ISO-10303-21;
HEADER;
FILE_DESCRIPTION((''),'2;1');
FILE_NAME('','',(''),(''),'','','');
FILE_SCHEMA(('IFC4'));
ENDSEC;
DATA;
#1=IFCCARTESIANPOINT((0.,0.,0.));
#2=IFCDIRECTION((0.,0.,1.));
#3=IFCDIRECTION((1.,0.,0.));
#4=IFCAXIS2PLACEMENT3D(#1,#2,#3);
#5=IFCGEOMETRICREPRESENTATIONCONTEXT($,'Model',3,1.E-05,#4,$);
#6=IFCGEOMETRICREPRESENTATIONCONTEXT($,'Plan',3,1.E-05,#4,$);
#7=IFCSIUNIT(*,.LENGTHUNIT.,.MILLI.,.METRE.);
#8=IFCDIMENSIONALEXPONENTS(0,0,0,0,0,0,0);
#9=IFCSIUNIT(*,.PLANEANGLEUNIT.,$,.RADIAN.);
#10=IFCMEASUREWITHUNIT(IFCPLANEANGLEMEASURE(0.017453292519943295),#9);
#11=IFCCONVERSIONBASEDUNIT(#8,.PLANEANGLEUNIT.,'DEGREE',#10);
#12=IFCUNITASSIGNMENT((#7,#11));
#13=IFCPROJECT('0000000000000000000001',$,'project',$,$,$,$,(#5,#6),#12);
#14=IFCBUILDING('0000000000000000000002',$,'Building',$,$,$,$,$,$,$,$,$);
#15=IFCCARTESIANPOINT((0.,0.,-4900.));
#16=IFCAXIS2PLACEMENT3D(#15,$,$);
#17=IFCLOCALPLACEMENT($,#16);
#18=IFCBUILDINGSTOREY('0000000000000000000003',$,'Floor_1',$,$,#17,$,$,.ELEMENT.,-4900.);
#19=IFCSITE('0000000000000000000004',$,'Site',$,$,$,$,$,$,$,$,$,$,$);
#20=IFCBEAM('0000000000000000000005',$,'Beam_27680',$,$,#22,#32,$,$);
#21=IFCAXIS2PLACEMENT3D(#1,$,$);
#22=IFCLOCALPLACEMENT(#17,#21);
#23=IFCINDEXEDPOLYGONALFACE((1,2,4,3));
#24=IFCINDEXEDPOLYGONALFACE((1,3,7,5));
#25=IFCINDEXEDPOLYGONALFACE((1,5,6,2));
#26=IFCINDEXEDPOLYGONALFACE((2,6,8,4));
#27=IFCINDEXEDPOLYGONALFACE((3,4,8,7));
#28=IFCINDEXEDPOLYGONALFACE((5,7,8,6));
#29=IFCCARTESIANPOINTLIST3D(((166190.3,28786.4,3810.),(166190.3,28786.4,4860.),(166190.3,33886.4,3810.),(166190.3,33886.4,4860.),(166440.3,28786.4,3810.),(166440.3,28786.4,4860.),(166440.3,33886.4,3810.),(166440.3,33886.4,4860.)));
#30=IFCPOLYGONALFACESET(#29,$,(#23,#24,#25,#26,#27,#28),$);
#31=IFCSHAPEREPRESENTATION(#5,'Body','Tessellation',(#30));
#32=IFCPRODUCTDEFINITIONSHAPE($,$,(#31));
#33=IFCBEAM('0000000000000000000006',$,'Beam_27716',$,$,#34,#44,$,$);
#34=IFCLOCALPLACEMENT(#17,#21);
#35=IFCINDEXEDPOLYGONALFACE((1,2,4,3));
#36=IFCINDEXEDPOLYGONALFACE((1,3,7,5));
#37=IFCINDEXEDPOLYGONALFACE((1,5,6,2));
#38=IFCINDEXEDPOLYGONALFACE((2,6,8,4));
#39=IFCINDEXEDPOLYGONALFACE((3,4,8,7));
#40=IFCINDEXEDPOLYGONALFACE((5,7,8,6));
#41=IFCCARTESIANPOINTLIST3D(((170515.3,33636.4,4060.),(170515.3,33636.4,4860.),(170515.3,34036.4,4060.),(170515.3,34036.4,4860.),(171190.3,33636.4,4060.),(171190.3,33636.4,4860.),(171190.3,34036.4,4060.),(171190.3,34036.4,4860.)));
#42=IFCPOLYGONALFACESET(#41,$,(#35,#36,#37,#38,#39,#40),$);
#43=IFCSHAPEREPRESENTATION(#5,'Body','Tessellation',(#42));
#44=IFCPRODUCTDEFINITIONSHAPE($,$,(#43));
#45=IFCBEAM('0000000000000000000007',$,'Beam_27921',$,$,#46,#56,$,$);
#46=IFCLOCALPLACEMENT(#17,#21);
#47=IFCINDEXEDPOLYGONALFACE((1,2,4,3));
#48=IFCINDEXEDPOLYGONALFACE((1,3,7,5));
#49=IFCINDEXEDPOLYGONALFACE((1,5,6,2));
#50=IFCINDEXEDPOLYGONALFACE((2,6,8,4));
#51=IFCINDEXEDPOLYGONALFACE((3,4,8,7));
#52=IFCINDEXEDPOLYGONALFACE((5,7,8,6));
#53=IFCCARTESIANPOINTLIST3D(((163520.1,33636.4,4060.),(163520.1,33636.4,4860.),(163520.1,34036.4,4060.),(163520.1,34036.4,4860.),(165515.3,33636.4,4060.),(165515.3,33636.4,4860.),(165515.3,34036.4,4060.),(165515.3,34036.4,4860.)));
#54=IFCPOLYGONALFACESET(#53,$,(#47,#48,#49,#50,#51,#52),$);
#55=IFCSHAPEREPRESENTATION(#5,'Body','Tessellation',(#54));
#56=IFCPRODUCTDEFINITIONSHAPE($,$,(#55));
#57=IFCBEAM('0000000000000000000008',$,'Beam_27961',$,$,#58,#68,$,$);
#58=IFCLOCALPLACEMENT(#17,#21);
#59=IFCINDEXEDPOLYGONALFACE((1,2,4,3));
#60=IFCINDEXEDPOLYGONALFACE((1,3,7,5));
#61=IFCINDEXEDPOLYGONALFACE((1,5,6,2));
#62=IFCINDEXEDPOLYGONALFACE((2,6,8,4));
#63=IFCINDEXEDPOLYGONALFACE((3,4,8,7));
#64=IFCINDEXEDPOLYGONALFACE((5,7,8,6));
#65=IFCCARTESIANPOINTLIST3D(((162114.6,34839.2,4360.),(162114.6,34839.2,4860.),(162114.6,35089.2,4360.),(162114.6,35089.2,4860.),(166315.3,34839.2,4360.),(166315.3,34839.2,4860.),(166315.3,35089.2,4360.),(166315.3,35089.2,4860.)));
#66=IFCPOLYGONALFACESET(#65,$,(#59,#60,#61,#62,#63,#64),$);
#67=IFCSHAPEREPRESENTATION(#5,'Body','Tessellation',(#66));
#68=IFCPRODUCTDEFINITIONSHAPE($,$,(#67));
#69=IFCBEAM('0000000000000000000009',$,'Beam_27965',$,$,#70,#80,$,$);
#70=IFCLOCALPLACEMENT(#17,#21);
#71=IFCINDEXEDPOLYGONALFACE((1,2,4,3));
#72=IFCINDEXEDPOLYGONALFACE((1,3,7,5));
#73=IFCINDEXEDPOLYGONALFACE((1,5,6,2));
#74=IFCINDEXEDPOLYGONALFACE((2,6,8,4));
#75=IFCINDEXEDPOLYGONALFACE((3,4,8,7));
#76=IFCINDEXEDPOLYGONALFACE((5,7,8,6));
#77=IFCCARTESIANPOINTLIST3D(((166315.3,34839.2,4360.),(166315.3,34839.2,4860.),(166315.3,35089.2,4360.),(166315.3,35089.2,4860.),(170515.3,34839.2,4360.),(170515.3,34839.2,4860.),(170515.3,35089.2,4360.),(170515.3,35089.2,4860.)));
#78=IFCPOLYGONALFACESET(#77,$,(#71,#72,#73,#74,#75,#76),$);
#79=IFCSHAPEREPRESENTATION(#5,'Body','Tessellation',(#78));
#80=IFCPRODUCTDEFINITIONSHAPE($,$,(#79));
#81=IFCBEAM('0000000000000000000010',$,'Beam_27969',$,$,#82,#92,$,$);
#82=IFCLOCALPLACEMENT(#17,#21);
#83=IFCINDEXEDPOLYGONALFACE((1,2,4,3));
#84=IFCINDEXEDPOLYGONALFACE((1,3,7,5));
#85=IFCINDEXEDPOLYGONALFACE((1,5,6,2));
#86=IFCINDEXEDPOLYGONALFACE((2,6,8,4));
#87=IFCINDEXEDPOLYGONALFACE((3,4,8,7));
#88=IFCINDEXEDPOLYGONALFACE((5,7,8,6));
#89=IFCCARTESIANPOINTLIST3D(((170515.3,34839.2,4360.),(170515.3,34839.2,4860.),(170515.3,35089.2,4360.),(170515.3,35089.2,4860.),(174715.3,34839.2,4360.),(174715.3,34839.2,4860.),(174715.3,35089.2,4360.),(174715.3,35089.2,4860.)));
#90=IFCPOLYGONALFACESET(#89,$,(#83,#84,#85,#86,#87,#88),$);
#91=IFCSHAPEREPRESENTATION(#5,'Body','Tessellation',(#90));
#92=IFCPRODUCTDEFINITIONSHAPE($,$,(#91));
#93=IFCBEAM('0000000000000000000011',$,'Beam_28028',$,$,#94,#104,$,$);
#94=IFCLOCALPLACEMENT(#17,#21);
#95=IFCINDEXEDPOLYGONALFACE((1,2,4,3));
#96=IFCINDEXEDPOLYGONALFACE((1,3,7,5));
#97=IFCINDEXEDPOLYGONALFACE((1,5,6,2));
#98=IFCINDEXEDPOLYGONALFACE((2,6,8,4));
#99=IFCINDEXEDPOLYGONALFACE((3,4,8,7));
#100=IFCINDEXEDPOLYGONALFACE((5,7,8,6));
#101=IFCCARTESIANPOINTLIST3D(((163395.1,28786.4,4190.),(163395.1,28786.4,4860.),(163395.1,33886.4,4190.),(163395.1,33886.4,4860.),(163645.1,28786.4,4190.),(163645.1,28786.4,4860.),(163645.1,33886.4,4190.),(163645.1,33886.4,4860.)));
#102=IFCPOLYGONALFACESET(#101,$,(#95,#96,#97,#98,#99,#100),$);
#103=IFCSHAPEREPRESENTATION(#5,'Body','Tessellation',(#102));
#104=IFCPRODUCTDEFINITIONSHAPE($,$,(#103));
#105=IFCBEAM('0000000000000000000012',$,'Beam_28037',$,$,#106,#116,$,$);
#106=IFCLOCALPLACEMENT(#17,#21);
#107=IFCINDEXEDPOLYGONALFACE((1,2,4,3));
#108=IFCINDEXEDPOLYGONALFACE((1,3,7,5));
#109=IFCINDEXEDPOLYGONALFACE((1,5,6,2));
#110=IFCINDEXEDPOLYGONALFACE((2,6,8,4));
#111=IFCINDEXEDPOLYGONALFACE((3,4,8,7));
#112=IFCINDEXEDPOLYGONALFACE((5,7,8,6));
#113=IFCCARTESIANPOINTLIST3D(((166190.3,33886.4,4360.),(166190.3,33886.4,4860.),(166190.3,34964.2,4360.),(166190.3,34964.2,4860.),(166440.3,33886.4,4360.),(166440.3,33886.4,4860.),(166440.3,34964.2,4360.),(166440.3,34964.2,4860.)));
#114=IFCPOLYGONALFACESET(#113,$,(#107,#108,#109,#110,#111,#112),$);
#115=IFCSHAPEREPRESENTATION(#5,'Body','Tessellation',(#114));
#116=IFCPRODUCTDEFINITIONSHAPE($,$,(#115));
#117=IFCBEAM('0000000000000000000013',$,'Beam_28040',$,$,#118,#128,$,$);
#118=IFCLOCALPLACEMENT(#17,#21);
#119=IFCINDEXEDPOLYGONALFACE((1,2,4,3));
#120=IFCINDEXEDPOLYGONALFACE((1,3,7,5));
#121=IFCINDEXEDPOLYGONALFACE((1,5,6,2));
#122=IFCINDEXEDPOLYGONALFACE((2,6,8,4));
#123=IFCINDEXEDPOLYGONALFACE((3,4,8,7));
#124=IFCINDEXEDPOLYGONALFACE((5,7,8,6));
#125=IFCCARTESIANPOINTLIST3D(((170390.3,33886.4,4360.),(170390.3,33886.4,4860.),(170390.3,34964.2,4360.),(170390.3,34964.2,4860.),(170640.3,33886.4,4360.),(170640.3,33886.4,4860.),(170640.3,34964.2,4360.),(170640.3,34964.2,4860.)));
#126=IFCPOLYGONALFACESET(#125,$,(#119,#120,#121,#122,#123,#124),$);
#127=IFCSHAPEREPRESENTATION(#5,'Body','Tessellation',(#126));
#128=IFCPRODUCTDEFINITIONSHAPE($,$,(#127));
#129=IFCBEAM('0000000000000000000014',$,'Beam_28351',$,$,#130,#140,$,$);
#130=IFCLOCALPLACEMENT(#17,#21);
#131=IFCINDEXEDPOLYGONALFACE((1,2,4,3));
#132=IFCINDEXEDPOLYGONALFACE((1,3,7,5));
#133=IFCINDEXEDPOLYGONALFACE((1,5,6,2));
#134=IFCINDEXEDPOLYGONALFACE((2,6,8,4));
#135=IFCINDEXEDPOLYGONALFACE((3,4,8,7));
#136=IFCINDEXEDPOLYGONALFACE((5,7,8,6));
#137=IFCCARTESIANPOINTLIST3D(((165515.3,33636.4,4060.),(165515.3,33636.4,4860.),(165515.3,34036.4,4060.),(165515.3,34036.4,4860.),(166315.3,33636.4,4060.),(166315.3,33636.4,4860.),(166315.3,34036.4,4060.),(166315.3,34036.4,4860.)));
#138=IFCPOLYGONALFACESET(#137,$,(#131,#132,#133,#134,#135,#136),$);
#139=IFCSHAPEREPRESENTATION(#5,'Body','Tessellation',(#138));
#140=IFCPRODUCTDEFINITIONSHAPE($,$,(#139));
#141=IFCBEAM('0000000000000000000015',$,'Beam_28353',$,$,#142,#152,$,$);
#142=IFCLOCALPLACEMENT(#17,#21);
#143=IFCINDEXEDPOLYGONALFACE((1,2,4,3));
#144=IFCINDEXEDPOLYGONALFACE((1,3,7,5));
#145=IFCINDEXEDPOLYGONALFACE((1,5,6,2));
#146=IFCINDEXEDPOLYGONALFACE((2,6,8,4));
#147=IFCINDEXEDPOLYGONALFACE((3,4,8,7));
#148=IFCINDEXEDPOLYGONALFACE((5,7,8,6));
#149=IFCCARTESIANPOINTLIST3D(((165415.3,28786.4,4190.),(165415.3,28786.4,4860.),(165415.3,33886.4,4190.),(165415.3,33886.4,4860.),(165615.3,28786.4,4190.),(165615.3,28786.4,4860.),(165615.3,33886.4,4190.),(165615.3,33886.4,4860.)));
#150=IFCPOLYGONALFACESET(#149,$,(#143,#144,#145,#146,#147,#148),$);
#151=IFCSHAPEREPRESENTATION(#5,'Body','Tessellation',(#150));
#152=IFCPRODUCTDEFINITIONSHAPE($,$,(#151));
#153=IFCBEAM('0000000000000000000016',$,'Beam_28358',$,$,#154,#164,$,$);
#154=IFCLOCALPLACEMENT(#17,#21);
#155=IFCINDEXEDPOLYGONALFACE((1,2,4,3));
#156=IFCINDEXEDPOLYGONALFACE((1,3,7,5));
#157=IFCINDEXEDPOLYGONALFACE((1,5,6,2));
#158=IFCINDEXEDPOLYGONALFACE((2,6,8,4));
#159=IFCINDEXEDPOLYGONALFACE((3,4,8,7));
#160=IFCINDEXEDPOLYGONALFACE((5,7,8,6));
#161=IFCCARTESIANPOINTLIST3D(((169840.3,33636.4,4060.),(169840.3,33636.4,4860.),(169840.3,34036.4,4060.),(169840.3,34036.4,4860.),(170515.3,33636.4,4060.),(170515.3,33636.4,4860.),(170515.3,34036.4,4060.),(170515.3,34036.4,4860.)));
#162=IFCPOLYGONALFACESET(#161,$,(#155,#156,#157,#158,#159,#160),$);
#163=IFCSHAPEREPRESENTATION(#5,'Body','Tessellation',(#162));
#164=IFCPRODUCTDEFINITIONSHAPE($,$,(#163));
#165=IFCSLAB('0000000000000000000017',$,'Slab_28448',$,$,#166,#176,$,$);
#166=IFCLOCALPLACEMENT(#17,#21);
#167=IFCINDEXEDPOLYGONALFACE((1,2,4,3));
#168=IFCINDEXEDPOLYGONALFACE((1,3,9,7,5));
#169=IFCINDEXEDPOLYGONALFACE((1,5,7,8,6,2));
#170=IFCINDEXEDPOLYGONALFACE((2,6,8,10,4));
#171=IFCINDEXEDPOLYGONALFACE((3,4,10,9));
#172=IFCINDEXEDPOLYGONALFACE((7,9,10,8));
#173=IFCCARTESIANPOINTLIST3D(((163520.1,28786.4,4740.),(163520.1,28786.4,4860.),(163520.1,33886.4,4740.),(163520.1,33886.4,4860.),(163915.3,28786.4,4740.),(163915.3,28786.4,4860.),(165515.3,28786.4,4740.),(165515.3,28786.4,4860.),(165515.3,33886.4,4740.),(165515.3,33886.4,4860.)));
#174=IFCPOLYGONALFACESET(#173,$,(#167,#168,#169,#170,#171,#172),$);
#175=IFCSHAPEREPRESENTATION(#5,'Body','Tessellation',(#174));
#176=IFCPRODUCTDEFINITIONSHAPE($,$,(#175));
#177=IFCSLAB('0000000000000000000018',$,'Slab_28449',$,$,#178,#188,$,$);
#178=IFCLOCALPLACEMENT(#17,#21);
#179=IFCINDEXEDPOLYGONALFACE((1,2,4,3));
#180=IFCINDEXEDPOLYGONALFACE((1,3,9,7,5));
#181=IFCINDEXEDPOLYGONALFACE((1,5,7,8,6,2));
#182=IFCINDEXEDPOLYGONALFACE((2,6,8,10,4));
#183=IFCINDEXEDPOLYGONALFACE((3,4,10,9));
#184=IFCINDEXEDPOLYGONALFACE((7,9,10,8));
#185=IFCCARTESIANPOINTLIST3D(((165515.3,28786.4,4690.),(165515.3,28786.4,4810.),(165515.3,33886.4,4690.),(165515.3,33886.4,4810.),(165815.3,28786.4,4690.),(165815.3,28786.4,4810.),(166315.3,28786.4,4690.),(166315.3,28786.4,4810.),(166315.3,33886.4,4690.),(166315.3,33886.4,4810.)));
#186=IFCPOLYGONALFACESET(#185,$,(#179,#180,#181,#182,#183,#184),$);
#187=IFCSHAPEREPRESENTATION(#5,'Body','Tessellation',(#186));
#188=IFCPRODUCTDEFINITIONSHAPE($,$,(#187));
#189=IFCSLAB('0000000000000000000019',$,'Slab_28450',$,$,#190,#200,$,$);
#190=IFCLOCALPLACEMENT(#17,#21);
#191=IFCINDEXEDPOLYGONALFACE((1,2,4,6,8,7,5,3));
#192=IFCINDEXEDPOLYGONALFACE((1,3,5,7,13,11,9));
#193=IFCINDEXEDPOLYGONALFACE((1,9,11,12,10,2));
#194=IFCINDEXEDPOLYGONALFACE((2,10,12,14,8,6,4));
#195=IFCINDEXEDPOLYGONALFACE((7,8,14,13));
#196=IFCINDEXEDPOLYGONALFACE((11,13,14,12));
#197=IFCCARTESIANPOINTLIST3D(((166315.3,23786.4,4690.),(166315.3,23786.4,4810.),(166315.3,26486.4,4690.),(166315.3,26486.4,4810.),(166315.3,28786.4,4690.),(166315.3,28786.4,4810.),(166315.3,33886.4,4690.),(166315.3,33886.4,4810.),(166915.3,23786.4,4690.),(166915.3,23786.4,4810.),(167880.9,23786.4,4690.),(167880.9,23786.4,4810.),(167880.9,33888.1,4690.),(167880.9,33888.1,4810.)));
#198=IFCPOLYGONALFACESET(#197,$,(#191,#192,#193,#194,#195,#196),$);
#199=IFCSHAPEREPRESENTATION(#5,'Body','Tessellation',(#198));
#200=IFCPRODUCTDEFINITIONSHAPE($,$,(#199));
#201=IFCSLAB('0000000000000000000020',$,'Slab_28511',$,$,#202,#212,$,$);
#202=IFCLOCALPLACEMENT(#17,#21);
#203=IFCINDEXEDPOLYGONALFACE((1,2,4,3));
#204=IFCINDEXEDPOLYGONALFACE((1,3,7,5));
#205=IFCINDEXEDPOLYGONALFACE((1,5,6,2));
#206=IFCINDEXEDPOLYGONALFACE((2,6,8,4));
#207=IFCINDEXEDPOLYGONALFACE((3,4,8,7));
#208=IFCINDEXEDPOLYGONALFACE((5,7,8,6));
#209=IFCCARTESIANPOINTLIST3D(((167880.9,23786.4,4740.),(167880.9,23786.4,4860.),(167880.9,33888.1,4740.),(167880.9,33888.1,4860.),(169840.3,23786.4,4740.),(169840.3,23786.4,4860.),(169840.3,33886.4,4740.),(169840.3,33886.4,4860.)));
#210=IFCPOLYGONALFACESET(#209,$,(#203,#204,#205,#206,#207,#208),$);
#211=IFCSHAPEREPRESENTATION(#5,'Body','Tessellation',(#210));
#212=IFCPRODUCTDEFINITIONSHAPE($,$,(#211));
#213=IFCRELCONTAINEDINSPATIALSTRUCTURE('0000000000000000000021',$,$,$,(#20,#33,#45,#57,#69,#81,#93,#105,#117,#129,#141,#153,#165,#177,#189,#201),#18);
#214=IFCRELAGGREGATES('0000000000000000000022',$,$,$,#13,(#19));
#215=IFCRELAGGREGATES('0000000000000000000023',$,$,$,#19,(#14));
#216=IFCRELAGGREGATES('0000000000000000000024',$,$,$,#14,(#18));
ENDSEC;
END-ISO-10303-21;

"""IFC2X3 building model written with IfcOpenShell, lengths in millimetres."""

from ifc_helpers import new_model, entity, si_unit, converted_unit, frame, origin_with_axes, origin_2d, place, context, project, spatial, polyline, rectangle, outline, extrude, element, save


model = new_model("IFC2X3")

# Units and contexts
model_context = context("Model", 3, precision=1e-05, world=origin_with_axes())
plan_context = context("Plan", 3, precision=1e-05, world=origin_with_axes())
ifc_project = project(units=[si_unit("LENGTHUNIT", "METRE", prefix="MILLI"), converted_unit("PLANEANGLEUNIT", "DEGREE", entity("IfcPlaneAngleMeasure", 0.017453292519943295), si_unit("PLANEANGLEUNIT", "RADIAN"), dimensions=[0, 0, 0, 0, 0, 0, 0])], contexts=[model_context, plan_context])

# Site, building, storey
site = spatial("IfcSite", under=ifc_project, Name="Site")
building = spatial("IfcBuilding", under=site, Name="Building")
storey_placement = place(None, frame((0.0, 0.0, -4900.0)))
storey = spatial("IfcBuildingStorey", under=building, at=storey_placement, Name="Floor_1", CompositionType="ELEMENT", Elevation=-4900.0)

# Beams
beam_1_placement = place(storey_placement, frame((166315.3, 28786.4, 4335.0), z_axis=(0.000484, 5099.99974, 0.0), x_axis=(5099.99974, -0.000484, 0.0)))
element("IfcBeam", 1, at=beam_1_placement, inside=storey, Name="Beam_27680", context=model_context, shape_type="SweptSolid", body=[
    extrude(rectangle(XDim=250.0, YDim=1050.0, at=origin_2d()), origin_with_axes(), (0.0, 0.0, 1.0), 5100.0),
])
beam_2_placement = place(storey_placement, frame((170515.3, 33836.4, 4460.0), z_axis=(675.0, 0.0, 0.0), x_axis=(0.0, -675.0, 0.0)))
element("IfcBeam", 2, at=beam_2_placement, inside=storey, Name="Beam_27716", context=model_context, shape_type="SweptSolid", body=[
    extrude(rectangle(XDim=400.0, YDim=800.0, at=origin_2d()), origin_with_axes(), (0.0, 0.0, 1.0), 675.0),
])
beam_3_placement = place(storey_placement, frame((163520.1, 33836.4, 4460.0), z_axis=(1995.269571, 0.0, 0.0), x_axis=(0.0, -1995.269571, 0.0)))
element("IfcBeam", 3, at=beam_3_placement, inside=storey, Name="Beam_27921", context=model_context, shape_type="SweptSolid", body=[
    extrude(rectangle(XDim=400.0, YDim=800.0, at=origin_2d()), origin_with_axes(), (0.0, 0.0, 1.0), 1995.3),
])
beam_4_placement = place(storey_placement, frame((162114.6, 34964.2, 4610.0), z_axis=(4200.682337, 0.0, 0.0), x_axis=(0.0, -4200.682337, 0.0)))
element("IfcBeam", 4, at=beam_4_placement, inside=storey, Name="Beam_27961", context=model_context, shape_type="SweptSolid", body=[
    extrude(rectangle(XDim=250.0, YDim=500.0, at=origin_2d()), origin_with_axes(), (0.0, 0.0, 1.0), 4200.7),
])
for number, where, z_axis, x_axis, name in (
    (5, (166315.3, 34964.2, 4610.0), (4200.0, 0.0, 0.0), (0.0, -4200.0, 0.0), "Beam_27965"),
    (6, (170515.3, 34964.2, 4610.0), (4200.0, 0.0, 0.0), (0.0, -4200.0, 0.0), "Beam_27969"),
):
    element("IfcBeam", number, at=place(storey_placement, frame(where, z_axis=z_axis, x_axis=x_axis)), inside=storey, Name=name, context=model_context, shape_type="SweptSolid", body=[
        extrude(rectangle(XDim=250.0, YDim=500.0, at=origin_2d()), origin_with_axes(), (0.0, 0.0, 1.0), 4200.0),
    ])
beam_5_placement = place(storey_placement, frame((163520.1, 28786.4, 4525.0), z_axis=(0.0, 5099.99974, 0.0), x_axis=(5099.99974, 0.0, 0.0)))
element("IfcBeam", 7, at=beam_5_placement, inside=storey, Name="Beam_28028", context=model_context, shape_type="SweptSolid", body=[
    extrude(rectangle(XDim=250.0, YDim=670.0, at=origin_2d()), origin_with_axes(), (0.0, 0.0, 1.0), 5100.0),
])
for number, where, z_axis, x_axis, name in (
    (8, (166315.3, 33886.4, 4610.0), (0.0, 1077.803188, 0.0), (1077.803188, 0.0, 0.0), "Beam_28037"),
    (9, (170515.3, 33886.4, 4610.0), (0.0, 1077.803188, 0.0), (1077.803188, 0.0, 0.0), "Beam_28040"),
):
    element("IfcBeam", number, at=place(storey_placement, frame(where, z_axis=z_axis, x_axis=x_axis)), inside=storey, Name=name, context=model_context, shape_type="SweptSolid", body=[
        extrude(rectangle(XDim=250.0, YDim=500.0, at=origin_2d()), origin_with_axes(), (0.0, 0.0, 1.0), 1077.8),
    ])
beam_6_placement = place(storey_placement, frame((165515.3, 33836.4, 4460.0), z_axis=(800.0, 0.0, 0.0), x_axis=(0.0, -800.0, 0.0)))
element("IfcBeam", 10, at=beam_6_placement, inside=storey, Name="Beam_28351", context=model_context, shape_type="SweptSolid", body=[
    extrude(rectangle(XDim=400.0, YDim=800.0, at=origin_2d()), origin_with_axes(), (0.0, 0.0, 1.0), 800.0),
])
beam_7_placement = place(storey_placement, frame((165515.3, 28786.4, 4525.0), z_axis=(0.0, 5099.99974, 0.0), x_axis=(5099.99974, 0.0, 0.0)))
element("IfcBeam", 11, at=beam_7_placement, inside=storey, Name="Beam_28353", context=model_context, shape_type="SweptSolid", body=[
    extrude(rectangle(XDim=200.0, YDim=670.0, at=origin_2d()), origin_with_axes(), (0.0, 0.0, 1.0), 5100.0),
])
beam_8_placement = place(storey_placement, frame((169840.3, 33836.4, 4460.0), z_axis=(675.0, 0.0, 0.0), x_axis=(0.0, -675.0, 0.0)))
element("IfcBeam", 12, at=beam_8_placement, inside=storey, Name="Beam_28358", context=model_context, shape_type="SweptSolid", body=[
    extrude(rectangle(XDim=400.0, YDim=800.0, at=origin_2d()), origin_with_axes(), (0.0, 0.0, 1.0), 675.0),
])

# Slabs
slab_1_placement = place(storey_placement, frame((163520.1, 33886.4, 4740.0), z_axis=(0.0, 0.0, 1.0), x_axis=(0.0, -5100.0, 0.0)))
element("IfcSlab", 13, at=slab_1_placement, inside=storey, Name="Slab_28448", context=model_context, shape_type="SweptSolid", body=[
    extrude(outline(polyline([(0.0, 0.0), (5100.0, 0.0), (5100.0, 395.3), (5100.0, 1995.3), (0.0, 1995.3)])), origin_with_axes(), (0.0, 0.0, 1.0), 120.0),
])
slab_2_placement = place(storey_placement, frame((165515.3, 33886.4, 4690.0), z_axis=(0.0, 0.0, 1.0), x_axis=(0.0, -5100.0, 0.0)))
element("IfcSlab", 14, at=slab_2_placement, inside=storey, Name="Slab_28449", context=model_context, shape_type="SweptSolid", body=[
    extrude(outline(polyline([(0.0, 0.0), (5100.0, 0.0), (5100.0, 300.0), (5100.0, 800.0), (0.0, 800.0)])), origin_with_axes(), (0.0, 0.0, 1.0), 120.0),
])
slab_3_placement = place(storey_placement, frame((166315.3, 33886.4, 4690.0), z_axis=(0.0, 0.0, 1.0), x_axis=(-0.001, -5100.0, 0.0)))
element("IfcSlab", 15, at=slab_3_placement, inside=storey, Name="Slab_28450", context=model_context, shape_type="SweptSolid", body=[
    extrude(outline(polyline([(0.0, 0.0), (5100.0, 0.0), (7400.0, 0.0), (10100.0, 0.0), (10100.0, 600.0), (10100.0, 1565.5), (-1.8, 1565.5)])), origin_with_axes(), (0.0, 0.0, 1.0), 120.0),
])
slab_4_placement = place(storey_placement, frame((167880.9, 33888.1, 4740.0), z_axis=(0.0, 0.0, 1.0), x_axis=(0.0, -10101.753, 0.0)))
element("IfcSlab", 16, at=slab_4_placement, inside=storey, Name="Slab_28511", context=model_context, shape_type="SweptSolid", body=[
    extrude(outline(polyline([(0.0, 0.0), (10101.8, 0.0), (10101.8, 1959.5), (1.8, 1959.5)])), origin_with_axes(), (0.0, 0.0, 1.0), 120.0),
])

save(model, "model.ifc")
